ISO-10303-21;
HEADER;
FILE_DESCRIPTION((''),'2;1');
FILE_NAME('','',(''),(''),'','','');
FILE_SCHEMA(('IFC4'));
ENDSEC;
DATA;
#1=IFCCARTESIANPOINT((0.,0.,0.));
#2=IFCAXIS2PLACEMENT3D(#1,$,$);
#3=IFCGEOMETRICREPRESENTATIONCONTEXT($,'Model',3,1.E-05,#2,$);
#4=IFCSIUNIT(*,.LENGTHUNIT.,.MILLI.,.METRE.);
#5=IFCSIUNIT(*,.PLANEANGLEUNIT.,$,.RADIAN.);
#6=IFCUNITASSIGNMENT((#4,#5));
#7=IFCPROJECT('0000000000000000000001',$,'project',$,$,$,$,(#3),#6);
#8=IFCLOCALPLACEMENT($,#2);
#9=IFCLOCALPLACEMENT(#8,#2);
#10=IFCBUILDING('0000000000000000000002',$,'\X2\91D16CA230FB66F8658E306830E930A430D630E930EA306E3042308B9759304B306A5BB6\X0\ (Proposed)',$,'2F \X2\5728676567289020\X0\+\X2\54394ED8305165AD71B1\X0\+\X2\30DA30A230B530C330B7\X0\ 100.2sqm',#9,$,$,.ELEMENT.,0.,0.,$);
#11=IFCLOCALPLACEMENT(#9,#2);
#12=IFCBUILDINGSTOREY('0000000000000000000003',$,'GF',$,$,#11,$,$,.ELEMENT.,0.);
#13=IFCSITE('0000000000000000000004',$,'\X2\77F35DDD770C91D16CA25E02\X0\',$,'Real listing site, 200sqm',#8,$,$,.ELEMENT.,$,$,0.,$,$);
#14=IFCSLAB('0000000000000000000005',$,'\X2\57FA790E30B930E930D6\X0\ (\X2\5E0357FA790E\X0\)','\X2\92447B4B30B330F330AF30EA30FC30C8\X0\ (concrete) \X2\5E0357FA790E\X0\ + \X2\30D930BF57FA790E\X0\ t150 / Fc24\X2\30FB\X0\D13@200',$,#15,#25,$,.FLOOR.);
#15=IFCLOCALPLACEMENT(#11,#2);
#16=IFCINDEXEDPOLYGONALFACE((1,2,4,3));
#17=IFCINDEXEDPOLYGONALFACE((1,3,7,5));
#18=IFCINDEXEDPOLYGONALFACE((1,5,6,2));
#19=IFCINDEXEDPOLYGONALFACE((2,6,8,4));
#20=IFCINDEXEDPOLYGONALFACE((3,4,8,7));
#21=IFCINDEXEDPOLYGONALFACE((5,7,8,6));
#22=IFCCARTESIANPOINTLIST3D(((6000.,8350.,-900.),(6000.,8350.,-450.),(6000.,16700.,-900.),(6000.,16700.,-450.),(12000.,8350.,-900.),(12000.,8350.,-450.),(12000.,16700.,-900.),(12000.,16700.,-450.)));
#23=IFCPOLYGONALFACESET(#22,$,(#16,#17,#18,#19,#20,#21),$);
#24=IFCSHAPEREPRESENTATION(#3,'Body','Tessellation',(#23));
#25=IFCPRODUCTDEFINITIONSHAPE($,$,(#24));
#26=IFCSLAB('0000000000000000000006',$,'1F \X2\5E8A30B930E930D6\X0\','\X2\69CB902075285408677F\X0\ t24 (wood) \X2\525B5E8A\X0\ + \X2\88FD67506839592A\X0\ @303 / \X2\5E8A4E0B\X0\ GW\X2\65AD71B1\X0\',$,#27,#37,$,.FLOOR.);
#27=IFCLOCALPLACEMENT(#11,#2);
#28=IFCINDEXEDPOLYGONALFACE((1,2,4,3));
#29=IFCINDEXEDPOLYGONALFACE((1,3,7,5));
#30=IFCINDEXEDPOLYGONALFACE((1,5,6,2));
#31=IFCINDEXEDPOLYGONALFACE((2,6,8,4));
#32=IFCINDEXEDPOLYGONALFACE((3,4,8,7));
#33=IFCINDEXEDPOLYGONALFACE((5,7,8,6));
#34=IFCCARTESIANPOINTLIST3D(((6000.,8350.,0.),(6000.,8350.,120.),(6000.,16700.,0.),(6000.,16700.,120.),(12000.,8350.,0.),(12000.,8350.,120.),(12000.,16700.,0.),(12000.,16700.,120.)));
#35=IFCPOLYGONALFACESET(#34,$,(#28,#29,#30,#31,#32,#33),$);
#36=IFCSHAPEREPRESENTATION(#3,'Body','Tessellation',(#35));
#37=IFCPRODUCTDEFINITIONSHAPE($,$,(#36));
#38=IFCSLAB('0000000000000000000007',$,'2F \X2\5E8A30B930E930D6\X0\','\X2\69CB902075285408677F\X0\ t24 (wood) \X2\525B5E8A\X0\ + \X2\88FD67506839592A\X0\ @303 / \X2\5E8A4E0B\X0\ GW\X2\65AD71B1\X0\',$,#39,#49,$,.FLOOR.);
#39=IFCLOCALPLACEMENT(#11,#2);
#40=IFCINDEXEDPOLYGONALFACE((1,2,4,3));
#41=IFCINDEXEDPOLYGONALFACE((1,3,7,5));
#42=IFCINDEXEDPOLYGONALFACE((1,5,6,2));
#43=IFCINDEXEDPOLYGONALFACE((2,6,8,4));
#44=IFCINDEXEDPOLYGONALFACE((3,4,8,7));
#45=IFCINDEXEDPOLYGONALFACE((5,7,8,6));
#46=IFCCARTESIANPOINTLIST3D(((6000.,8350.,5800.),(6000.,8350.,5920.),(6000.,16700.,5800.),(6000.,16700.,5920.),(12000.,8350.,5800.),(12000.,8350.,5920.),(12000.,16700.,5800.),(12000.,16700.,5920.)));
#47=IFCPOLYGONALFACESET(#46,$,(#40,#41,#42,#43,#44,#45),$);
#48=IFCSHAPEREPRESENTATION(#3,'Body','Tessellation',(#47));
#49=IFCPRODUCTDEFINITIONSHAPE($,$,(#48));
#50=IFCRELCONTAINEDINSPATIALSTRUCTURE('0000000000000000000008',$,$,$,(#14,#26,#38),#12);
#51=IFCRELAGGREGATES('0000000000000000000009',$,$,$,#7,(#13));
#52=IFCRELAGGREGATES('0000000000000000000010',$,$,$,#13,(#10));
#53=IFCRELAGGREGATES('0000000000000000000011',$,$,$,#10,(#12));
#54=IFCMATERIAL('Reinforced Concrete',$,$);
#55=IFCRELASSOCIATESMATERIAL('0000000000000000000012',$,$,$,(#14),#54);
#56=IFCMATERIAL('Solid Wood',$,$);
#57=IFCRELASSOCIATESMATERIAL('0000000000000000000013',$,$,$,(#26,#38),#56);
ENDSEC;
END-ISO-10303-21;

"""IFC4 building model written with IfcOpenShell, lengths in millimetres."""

from ifc_helpers import new_model, si_unit, frame, frame_2d, origin, place, context, project, spatial, rectangle, extrude, material, element, save


model = new_model("IFC4")

# Units and contexts
model_context = context("Model", 3, precision=1e-05, world=origin())
ifc_project = project(units=[si_unit("LENGTHUNIT", "METRE", prefix="MILLI"), si_unit("PLANEANGLEUNIT", "RADIAN")], contexts=[model_context])

# Site, building, storey
site_placement = place(None, origin())
site = spatial("IfcSite", under=ifc_project, at=site_placement, Name="石川県金沢市", ObjectType="Real listing site, 200sqm", CompositionType="ELEMENT", RefElevation=0.0)
building_placement = place(site_placement, origin())
building = spatial("IfcBuilding", under=site, at=building_placement, Name="金沢・書斎とライブラリのある静かな家 (Proposed)", ObjectType="2F 在来木造+吹付け断熱+ペアサッシ 100.2sqm", CompositionType="ELEMENT", ElevationOfRefHeight=0.0, ElevationOfTerrain=0.0)
storey_placement = place(building_placement, origin())
storey = spatial("IfcBuildingStorey", under=building, at=storey_placement, Name="GF", CompositionType="ELEMENT", Elevation=0.0)

# Shared definitions
ifc_material_1 = material(Name="Solid Wood")

# Slabs
ifc_material_2 = material(Name="Reinforced Concrete")
slab_1_placement = place(storey_placement, frame((3000.0, 4175.0, -450.0)))
element("IfcSlab", 1, at=slab_1_placement, inside=storey, material=ifc_material_2, Name="基礎スラブ (布基礎)", Description="鉄筋コンクリート (concrete) 布基礎 + ベタ基礎 t150 / Fc24・D13@200", PredefinedType="FLOOR", context=model_context, shape_type="SweptSolid", body=[
    extrude(rectangle(XDim=6000.0, YDim=8350.0, at=frame_2d((3000.0, 4175.0))), frame((3000.0, 4175.0, -450.0)), (0.0, 0.0, 1.0), 450.0),
])
slab_2_placement = place(storey_placement, frame((3000.0, 4175.0, 0.0)))
element("IfcSlab", 2, at=slab_2_placement, inside=storey, material=ifc_material_1, Name="1F 床スラブ", Description="構造用合板 t24 (wood) 剛床 + 製材根太 @303 / 床下 GW断熱", PredefinedType="FLOOR", context=model_context, shape_type="SweptSolid", body=[
    extrude(rectangle(XDim=6000.0, YDim=8350.0, at=frame_2d((3000.0, 4175.0))), frame((3000.0, 4175.0, 0.0)), (0.0, 0.0, 1.0), 120.0),
])
slab_3_placement = place(storey_placement, frame((3000.0, 4175.0, 2900.0)))
element("IfcSlab", 3, at=slab_3_placement, inside=storey, material=ifc_material_1, Name="2F 床スラブ", Description="構造用合板 t24 (wood) 剛床 + 製材根太 @303 / 床下 GW断熱", PredefinedType="FLOOR", context=model_context, shape_type="SweptSolid", body=[
    extrude(rectangle(XDim=6000.0, YDim=8350.0, at=frame_2d((3000.0, 4175.0))), frame((3000.0, 4175.0, 2900.0)), (0.0, 0.0, 1.0), 120.0),
])

save(model, "model.ifc")
